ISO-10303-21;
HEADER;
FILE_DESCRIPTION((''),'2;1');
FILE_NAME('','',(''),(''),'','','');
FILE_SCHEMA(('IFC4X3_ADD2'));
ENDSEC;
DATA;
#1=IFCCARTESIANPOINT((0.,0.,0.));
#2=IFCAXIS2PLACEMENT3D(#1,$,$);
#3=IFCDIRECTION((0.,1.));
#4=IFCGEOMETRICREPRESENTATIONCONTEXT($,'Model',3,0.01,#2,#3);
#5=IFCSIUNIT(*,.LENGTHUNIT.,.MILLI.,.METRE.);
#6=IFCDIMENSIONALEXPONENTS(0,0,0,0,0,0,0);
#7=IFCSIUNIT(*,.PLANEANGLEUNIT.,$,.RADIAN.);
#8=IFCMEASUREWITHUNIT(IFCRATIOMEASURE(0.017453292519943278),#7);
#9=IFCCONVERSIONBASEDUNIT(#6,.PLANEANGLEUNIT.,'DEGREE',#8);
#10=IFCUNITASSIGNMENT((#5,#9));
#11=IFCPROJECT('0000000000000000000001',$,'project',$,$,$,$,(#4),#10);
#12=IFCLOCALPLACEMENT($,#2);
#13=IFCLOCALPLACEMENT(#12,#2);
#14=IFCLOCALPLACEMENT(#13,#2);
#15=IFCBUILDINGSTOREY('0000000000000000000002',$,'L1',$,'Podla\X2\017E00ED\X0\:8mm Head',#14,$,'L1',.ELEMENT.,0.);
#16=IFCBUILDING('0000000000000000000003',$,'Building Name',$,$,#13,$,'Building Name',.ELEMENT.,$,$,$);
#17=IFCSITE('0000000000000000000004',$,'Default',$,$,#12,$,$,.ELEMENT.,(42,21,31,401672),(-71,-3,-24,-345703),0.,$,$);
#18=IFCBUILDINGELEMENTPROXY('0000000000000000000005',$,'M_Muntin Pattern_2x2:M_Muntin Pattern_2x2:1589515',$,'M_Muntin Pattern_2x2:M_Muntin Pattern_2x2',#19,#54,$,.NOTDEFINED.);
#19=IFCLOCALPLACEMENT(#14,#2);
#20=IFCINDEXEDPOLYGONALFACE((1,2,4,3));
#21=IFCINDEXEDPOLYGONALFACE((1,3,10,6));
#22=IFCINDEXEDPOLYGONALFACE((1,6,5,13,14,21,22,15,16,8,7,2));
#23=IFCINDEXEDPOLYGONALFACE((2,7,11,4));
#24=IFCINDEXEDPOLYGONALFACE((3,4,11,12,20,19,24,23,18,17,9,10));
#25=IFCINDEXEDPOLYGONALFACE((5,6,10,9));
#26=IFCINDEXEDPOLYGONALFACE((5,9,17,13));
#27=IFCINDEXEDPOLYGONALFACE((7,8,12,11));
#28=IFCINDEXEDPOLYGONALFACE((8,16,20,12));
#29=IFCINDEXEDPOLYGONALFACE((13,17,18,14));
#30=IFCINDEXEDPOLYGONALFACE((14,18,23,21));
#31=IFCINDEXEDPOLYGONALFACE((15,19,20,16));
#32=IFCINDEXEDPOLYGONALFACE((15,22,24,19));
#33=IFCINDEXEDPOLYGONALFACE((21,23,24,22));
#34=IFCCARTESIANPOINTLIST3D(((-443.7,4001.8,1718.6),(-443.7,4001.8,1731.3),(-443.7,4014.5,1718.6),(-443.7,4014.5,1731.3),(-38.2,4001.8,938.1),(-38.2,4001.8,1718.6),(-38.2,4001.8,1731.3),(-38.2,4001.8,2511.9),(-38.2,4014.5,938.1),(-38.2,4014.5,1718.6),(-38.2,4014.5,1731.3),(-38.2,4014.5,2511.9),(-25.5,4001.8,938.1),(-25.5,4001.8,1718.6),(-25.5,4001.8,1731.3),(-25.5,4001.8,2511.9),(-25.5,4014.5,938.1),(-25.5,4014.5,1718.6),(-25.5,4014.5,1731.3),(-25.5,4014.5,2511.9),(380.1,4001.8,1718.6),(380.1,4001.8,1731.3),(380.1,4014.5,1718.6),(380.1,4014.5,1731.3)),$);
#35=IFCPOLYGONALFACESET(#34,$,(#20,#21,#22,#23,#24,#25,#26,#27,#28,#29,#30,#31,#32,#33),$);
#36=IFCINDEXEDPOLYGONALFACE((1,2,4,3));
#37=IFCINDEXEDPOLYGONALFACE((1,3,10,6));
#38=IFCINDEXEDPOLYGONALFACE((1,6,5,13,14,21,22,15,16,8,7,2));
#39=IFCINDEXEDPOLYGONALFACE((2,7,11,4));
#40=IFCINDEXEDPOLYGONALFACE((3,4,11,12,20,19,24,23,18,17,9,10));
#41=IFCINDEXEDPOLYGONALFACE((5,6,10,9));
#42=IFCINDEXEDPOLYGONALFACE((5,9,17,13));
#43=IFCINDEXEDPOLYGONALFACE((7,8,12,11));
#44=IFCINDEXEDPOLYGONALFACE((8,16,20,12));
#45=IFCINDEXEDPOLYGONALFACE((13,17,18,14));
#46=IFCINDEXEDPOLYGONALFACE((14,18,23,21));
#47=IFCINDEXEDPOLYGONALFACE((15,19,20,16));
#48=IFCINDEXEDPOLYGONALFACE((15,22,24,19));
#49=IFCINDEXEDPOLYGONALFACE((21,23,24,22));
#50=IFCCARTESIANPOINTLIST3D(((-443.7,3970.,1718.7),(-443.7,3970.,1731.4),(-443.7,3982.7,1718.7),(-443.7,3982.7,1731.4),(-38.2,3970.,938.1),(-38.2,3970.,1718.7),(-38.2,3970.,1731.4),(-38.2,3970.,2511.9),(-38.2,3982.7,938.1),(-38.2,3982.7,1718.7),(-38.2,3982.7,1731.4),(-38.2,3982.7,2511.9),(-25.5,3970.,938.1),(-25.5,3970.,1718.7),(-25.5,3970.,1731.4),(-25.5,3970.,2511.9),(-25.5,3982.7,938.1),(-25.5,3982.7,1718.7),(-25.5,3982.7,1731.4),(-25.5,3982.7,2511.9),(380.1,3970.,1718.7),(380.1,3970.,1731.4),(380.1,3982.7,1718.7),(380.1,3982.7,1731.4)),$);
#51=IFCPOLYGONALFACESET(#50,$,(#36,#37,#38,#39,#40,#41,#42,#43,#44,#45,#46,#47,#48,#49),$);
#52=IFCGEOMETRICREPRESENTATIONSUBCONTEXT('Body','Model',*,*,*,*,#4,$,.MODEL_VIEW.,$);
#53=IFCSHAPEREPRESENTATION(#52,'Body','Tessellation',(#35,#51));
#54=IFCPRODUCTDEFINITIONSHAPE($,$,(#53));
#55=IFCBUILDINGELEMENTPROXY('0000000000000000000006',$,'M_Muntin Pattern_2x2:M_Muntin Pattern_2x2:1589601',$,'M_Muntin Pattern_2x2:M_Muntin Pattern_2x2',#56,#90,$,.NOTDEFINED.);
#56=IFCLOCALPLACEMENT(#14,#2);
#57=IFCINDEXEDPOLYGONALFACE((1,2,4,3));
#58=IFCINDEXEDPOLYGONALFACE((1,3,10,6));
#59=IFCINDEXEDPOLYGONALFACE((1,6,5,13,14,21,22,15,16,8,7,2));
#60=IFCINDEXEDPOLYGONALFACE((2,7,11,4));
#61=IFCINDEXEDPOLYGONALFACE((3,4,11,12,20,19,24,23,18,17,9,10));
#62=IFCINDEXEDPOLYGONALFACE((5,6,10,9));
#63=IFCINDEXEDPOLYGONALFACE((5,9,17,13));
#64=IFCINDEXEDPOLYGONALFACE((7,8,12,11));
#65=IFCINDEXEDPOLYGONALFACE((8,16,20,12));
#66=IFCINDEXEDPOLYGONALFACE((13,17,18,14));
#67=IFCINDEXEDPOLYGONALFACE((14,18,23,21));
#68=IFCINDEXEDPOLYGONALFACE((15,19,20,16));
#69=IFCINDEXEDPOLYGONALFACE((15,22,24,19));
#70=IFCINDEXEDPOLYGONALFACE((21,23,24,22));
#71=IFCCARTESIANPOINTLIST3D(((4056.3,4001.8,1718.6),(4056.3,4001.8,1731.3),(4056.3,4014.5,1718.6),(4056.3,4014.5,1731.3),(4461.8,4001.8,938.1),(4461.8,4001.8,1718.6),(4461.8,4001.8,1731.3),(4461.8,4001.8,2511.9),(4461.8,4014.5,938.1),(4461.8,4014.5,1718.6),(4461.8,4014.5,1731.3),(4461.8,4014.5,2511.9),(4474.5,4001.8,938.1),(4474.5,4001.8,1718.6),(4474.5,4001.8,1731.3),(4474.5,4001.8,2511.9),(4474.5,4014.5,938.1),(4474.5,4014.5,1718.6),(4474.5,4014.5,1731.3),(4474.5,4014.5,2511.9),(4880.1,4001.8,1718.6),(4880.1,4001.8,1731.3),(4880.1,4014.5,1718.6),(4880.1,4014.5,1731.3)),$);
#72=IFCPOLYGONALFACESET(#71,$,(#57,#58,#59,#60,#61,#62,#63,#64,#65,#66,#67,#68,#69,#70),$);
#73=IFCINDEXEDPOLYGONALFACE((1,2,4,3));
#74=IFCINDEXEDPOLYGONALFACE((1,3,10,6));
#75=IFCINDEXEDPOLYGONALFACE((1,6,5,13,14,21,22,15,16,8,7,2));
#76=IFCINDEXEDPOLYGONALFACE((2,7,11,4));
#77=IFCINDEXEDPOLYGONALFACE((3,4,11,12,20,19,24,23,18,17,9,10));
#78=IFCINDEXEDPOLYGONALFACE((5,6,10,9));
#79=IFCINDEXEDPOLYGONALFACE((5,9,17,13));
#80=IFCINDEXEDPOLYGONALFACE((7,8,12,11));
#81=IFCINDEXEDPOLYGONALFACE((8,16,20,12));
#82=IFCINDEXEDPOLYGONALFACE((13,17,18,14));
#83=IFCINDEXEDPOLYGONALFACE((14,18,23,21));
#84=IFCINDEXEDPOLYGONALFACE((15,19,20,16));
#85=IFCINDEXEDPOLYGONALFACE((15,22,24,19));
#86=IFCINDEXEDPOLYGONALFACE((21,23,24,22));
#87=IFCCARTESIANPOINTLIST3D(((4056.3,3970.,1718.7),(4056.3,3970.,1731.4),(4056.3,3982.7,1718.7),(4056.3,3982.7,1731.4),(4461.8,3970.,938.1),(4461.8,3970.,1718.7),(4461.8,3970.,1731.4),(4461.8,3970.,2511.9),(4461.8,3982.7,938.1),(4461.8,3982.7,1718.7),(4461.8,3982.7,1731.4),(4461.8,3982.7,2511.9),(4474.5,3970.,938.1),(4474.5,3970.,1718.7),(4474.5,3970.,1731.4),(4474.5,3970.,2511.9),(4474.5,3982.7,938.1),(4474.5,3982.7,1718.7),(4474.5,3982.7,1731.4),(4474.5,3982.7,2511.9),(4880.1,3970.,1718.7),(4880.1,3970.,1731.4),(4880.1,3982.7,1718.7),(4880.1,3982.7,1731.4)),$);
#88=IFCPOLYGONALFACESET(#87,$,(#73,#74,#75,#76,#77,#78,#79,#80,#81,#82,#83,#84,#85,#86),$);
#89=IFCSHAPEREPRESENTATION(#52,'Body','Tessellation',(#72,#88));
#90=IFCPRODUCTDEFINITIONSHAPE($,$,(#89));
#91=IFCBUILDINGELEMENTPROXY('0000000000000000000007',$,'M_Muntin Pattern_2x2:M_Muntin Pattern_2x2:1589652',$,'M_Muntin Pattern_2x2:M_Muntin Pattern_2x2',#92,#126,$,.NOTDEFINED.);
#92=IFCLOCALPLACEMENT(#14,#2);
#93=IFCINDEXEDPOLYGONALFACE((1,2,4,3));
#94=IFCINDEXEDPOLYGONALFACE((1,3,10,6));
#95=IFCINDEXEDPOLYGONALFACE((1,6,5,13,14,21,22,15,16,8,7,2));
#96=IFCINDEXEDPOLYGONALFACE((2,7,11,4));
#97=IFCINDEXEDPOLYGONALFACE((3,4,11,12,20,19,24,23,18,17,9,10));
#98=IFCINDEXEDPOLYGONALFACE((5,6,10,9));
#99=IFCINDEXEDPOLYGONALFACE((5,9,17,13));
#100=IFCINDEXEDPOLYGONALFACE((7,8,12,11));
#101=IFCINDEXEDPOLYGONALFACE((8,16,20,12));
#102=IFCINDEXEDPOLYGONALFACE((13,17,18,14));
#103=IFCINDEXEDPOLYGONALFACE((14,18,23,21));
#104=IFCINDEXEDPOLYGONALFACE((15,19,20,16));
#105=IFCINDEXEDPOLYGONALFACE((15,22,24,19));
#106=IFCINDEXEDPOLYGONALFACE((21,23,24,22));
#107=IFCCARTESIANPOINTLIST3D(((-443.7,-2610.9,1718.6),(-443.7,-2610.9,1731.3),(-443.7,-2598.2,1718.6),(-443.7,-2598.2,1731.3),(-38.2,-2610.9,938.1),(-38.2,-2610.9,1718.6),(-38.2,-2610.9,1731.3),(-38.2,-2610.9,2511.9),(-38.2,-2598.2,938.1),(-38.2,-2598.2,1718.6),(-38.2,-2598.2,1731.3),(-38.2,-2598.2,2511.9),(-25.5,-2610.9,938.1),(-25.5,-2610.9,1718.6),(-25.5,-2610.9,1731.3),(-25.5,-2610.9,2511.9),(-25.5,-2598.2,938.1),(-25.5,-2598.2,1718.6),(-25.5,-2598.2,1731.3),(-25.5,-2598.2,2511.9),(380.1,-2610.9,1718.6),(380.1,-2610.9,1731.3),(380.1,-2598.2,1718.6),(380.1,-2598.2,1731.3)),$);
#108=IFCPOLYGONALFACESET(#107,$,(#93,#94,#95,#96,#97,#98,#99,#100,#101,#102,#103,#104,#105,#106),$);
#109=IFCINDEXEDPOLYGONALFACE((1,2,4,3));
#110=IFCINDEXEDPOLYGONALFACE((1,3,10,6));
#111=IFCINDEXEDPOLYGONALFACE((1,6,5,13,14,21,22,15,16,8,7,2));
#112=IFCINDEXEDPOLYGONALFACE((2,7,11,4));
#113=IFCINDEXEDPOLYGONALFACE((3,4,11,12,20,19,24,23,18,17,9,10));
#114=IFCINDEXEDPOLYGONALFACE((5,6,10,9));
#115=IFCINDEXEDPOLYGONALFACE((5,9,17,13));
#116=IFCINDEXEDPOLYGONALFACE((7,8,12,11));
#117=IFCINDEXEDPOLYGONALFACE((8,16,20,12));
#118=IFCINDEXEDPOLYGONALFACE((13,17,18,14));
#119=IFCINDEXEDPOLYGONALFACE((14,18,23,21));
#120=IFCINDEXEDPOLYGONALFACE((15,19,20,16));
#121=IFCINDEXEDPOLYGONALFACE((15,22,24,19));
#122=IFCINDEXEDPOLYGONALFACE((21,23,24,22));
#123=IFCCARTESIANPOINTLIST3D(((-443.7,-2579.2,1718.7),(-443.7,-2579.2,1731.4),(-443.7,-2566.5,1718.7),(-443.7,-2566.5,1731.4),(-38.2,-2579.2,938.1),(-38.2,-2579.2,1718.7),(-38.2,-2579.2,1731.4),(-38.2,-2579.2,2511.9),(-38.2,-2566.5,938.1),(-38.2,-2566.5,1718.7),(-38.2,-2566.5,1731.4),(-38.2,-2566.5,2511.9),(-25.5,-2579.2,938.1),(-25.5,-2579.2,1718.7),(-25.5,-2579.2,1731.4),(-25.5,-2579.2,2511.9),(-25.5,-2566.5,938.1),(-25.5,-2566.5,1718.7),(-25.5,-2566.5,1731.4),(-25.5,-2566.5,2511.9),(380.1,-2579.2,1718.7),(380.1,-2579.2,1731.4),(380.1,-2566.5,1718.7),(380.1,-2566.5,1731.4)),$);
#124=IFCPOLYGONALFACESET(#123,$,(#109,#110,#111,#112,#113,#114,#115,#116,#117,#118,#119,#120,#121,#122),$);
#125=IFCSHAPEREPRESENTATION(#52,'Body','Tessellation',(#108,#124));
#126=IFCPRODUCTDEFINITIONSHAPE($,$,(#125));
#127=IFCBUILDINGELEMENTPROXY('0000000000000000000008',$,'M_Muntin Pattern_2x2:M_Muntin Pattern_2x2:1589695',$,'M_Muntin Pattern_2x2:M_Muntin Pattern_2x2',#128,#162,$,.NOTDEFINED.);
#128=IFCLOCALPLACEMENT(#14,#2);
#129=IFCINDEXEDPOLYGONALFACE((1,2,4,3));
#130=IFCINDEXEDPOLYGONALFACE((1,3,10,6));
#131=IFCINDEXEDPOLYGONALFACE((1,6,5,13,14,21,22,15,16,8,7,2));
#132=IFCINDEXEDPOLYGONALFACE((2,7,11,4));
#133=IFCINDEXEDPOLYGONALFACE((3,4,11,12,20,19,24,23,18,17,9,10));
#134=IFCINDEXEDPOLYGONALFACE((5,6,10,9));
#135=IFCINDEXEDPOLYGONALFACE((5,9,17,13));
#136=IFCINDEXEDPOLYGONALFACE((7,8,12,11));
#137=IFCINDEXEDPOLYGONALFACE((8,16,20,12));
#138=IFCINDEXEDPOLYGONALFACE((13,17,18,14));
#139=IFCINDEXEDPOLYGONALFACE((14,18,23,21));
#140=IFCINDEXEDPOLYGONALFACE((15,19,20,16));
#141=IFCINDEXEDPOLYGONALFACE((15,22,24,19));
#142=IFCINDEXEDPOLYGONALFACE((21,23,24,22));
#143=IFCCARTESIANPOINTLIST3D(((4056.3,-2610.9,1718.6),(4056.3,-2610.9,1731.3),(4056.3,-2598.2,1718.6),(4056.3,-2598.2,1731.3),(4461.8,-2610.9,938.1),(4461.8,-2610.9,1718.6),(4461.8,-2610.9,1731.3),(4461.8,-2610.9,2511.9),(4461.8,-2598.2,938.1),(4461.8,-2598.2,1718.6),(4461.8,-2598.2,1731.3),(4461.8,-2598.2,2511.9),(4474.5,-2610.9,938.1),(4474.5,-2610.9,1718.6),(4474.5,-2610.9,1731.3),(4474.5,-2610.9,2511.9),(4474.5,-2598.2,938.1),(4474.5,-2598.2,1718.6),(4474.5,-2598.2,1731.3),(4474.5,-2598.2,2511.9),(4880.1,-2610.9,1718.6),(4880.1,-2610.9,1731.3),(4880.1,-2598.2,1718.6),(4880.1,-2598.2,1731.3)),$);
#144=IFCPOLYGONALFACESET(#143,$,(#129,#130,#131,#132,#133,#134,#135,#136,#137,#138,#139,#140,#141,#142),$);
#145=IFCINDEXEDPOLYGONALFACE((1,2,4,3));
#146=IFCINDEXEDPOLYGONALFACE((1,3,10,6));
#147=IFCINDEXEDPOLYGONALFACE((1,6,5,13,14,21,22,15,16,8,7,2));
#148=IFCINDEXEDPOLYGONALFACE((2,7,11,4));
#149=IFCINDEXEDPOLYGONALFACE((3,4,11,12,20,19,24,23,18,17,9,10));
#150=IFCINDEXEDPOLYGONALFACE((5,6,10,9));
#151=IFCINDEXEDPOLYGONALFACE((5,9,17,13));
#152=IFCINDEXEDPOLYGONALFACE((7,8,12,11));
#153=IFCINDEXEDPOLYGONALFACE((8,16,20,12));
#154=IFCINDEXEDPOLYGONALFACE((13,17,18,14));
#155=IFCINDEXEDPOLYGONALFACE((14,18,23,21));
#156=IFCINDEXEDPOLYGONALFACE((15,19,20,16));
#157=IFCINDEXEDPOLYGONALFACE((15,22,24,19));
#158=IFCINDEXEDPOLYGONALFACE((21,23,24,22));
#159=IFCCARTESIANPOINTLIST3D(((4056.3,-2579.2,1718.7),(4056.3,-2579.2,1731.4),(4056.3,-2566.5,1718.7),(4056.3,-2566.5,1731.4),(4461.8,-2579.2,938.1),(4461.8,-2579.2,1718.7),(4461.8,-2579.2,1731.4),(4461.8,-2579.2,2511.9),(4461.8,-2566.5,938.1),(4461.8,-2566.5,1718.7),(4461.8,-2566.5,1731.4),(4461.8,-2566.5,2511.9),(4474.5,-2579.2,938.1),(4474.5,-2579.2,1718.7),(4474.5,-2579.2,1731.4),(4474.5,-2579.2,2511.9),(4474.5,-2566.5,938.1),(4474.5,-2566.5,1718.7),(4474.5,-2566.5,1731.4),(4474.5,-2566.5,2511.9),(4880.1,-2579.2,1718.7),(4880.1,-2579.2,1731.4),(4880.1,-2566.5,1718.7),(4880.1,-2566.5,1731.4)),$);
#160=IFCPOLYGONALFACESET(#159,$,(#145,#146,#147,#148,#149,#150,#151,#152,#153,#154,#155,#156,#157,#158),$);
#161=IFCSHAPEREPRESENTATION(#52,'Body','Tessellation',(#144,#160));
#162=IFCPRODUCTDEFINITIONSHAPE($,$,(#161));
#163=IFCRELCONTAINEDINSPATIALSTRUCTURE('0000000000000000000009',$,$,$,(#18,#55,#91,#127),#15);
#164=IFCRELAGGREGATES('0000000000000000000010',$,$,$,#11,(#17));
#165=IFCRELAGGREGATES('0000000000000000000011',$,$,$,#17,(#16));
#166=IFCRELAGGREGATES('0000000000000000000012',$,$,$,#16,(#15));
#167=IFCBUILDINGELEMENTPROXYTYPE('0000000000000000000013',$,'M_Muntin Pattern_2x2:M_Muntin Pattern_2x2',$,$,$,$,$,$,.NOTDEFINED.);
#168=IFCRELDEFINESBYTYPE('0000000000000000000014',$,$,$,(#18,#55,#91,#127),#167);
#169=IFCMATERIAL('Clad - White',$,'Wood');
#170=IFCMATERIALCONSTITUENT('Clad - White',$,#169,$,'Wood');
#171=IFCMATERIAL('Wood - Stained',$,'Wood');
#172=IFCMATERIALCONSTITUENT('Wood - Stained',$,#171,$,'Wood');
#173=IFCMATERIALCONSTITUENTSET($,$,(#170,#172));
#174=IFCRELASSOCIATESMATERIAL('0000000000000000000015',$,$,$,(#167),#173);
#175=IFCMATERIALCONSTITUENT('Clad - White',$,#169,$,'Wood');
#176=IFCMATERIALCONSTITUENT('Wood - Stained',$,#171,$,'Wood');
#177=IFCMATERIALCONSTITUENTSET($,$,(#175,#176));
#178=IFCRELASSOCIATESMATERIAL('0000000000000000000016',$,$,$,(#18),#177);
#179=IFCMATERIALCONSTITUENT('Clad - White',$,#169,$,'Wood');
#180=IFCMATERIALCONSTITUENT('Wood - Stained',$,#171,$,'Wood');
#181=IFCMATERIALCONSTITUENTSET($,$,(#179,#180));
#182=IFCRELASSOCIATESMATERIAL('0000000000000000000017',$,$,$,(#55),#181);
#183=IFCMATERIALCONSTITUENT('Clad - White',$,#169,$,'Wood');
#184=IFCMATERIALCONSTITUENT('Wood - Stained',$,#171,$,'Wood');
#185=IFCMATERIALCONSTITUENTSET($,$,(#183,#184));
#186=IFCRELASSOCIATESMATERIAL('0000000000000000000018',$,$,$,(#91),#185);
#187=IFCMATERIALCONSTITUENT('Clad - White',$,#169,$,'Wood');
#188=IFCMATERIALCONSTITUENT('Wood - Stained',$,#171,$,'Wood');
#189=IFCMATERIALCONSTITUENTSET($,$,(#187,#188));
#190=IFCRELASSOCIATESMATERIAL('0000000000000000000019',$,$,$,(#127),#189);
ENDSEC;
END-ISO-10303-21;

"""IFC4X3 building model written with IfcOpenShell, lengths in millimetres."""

from ifc_helpers import new_model, entity, si_unit, converted_unit, direction, frame, origin, place, context, subcontext, project, spatial, polyline, outline, extrude, source, transform, mapped, material, constituent, constituent_set, type_object, type_shapes, element, save


model = new_model("IFC4X3")

# Units and contexts
model_context = context("Model", 3, precision=0.01, world=origin(), true_north=direction((0.0, 1.0)))
body_context = subcontext(model_context, "Body", "Model", "MODEL_VIEW")
ifc_project = project(units=[si_unit("LENGTHUNIT", "METRE", prefix="MILLI"), converted_unit("PLANEANGLEUNIT", "DEGREE", entity("IfcRatioMeasure", 0.017453292519943278), si_unit("PLANEANGLEUNIT", "RADIAN"), dimensions=[0, 0, 0, 0, 0, 0, 0])], contexts=[model_context])

# Site, building, storey
site_placement = place(None, origin())
site = spatial("IfcSite", under=ifc_project, at=site_placement, Name="Default", CompositionType="ELEMENT", RefLatitude=(42, 21, 31, 401672), RefLongitude=(-71, -3, -24, -345703), RefElevation=0.0)
building_placement = place(site_placement, origin())
building = spatial("IfcBuilding", under=site, at=building_placement, Name="Building Name", LongName="Building Name", CompositionType="ELEMENT")
storey_placement = place(building_placement, origin())
storey = spatial("IfcBuildingStorey", under=building, at=storey_placement, Name="L1", ObjectType="Podlaží:8mm Head", LongName="L1", CompositionType="ELEMENT", Elevation=0.0)

# Building element proxies
ifc_material_1 = material(Name="Clad - White", Category="Wood")
ifc_constituent_1 = constituent(ifc_material_1, Name="Clad - White", Category="Wood")
ifc_material_2 = material(Name="Wood - Stained", Category="Wood")
ifc_constituent_2 = constituent(ifc_material_2, Name="Wood - Stained", Category="Wood")
ifc_constituent_set_1 = constituent_set(constituents=[ifc_constituent_1, ifc_constituent_2])
ifc_constituent_3 = constituent(ifc_material_1, Name="Clad - White", Category="Wood")
ifc_constituent_4 = constituent(ifc_material_2, Name="Wood - Stained", Category="Wood")
ifc_constituent_set_2 = constituent_set(constituents=[ifc_constituent_3, ifc_constituent_4])
building_element_proxy_type_1 = type_object("IfcBuildingElementProxyType", Name="M_Muntin Pattern_2x2:M_Muntin Pattern_2x2", PredefinedType="NOTDEFINED", material=ifc_constituent_set_2)
shared_shape_1 = source(origin(), body_context, "Body", "SweptSolid", [
    extrude(outline(polyline([(6.4, -6.4), (786.9, -6.4), (786.9, 6.3), (6.4, 6.3), (6.4, 411.9), (-6.3, 411.9), (-6.3, 6.3), (-786.9, 6.3), (-786.9, -6.4), (-6.3, -6.4), (-6.3, -411.9), (6.4, -411.9), (6.4, -6.4)])), frame((0.0, -22.2, 786.9), z_axis=(0.0, 1.0, 0.0), x_axis=(0.0, 0.0, 1.0)), (0.0, 0.0, 1.0), 12.7),
    extrude(outline(polyline([(6.4, -6.4), (786.9, -6.4), (786.9, 6.3), (6.4, 6.3), (6.4, 411.9), (-6.3, 411.9), (-6.3, 6.3), (-786.9, 6.3), (-786.9, -6.4), (-6.3, -6.4), (-6.3, -411.9), (6.4, -411.9), (6.4, -6.4)])), frame((0.0, 9.5, 786.9), z_axis=(0.0, 1.0, 0.0), x_axis=(0.0, 0.0, 1.0)), (0.0, 0.0, 1.0), 12.7),
])
type_shapes(building_element_proxy_type_1, [shared_shape_1])
proxy_1_placement = place(storey_placement, frame((-31.8, 3992.2, 938.1), z_axis=(0.0, 0.0, 1.0), x_axis=(-1.0, 0.0, 0.0)))
element("IfcBuildingElementProxy", 1, at=proxy_1_placement, inside=storey, type_object=building_element_proxy_type_1, material=ifc_constituent_set_1, Name="M_Muntin Pattern_2x2:M_Muntin Pattern_2x2:1589515", ObjectType="M_Muntin Pattern_2x2:M_Muntin Pattern_2x2", PredefinedType="NOTDEFINED", context=body_context, shape_type="MappedRepresentation", body=[
    mapped(shared_shape_1, transform((0.0, 0.0, 0.0), scale=1.0)),
])
ifc_constituent_5 = constituent(ifc_material_1, Name="Clad - White", Category="Wood")
ifc_constituent_6 = constituent(ifc_material_2, Name="Wood - Stained", Category="Wood")
ifc_constituent_set_3 = constituent_set(constituents=[ifc_constituent_5, ifc_constituent_6])
proxy_2_placement = place(storey_placement, frame((4468.2, 3992.2, 938.1), z_axis=(0.0, 0.0, 1.0), x_axis=(-1.0, 0.0, 0.0)))
element("IfcBuildingElementProxy", 2, at=proxy_2_placement, inside=storey, type_object=building_element_proxy_type_1, material=ifc_constituent_set_3, Name="M_Muntin Pattern_2x2:M_Muntin Pattern_2x2:1589601", ObjectType="M_Muntin Pattern_2x2:M_Muntin Pattern_2x2", PredefinedType="NOTDEFINED", context=body_context, shape_type="MappedRepresentation", body=[
    mapped(shared_shape_1, transform((0.0, 0.0, 0.0), scale=1.0)),
])
ifc_constituent_7 = constituent(ifc_material_1, Name="Clad - White", Category="Wood")
ifc_constituent_8 = constituent(ifc_material_2, Name="Wood - Stained", Category="Wood")
ifc_constituent_set_4 = constituent_set(constituents=[ifc_constituent_7, ifc_constituent_8])
proxy_3_placement = place(storey_placement, frame((-31.8, -2588.7, 938.1)))
element("IfcBuildingElementProxy", 3, at=proxy_3_placement, inside=storey, type_object=building_element_proxy_type_1, material=ifc_constituent_set_4, Name="M_Muntin Pattern_2x2:M_Muntin Pattern_2x2:1589652", ObjectType="M_Muntin Pattern_2x2:M_Muntin Pattern_2x2", PredefinedType="NOTDEFINED", context=body_context, shape_type="MappedRepresentation", body=[
    mapped(shared_shape_1, transform((0.0, 0.0, 0.0), scale=1.0)),
])
ifc_constituent_9 = constituent(ifc_material_1, Name="Clad - White", Category="Wood")
ifc_constituent_10 = constituent(ifc_material_2, Name="Wood - Stained", Category="Wood")
ifc_constituent_set_5 = constituent_set(constituents=[ifc_constituent_9, ifc_constituent_10])
proxy_4_placement = place(storey_placement, frame((4468.2, -2588.7, 938.1)))
element("IfcBuildingElementProxy", 4, at=proxy_4_placement, inside=storey, type_object=building_element_proxy_type_1, material=ifc_constituent_set_5, Name="M_Muntin Pattern_2x2:M_Muntin Pattern_2x2:1589695", ObjectType="M_Muntin Pattern_2x2:M_Muntin Pattern_2x2", PredefinedType="NOTDEFINED", context=body_context, shape_type="MappedRepresentation", body=[
    mapped(shared_shape_1, transform((0.0, 0.0, 0.0), scale=1.0)),
])

save(model, "model.ifc")
